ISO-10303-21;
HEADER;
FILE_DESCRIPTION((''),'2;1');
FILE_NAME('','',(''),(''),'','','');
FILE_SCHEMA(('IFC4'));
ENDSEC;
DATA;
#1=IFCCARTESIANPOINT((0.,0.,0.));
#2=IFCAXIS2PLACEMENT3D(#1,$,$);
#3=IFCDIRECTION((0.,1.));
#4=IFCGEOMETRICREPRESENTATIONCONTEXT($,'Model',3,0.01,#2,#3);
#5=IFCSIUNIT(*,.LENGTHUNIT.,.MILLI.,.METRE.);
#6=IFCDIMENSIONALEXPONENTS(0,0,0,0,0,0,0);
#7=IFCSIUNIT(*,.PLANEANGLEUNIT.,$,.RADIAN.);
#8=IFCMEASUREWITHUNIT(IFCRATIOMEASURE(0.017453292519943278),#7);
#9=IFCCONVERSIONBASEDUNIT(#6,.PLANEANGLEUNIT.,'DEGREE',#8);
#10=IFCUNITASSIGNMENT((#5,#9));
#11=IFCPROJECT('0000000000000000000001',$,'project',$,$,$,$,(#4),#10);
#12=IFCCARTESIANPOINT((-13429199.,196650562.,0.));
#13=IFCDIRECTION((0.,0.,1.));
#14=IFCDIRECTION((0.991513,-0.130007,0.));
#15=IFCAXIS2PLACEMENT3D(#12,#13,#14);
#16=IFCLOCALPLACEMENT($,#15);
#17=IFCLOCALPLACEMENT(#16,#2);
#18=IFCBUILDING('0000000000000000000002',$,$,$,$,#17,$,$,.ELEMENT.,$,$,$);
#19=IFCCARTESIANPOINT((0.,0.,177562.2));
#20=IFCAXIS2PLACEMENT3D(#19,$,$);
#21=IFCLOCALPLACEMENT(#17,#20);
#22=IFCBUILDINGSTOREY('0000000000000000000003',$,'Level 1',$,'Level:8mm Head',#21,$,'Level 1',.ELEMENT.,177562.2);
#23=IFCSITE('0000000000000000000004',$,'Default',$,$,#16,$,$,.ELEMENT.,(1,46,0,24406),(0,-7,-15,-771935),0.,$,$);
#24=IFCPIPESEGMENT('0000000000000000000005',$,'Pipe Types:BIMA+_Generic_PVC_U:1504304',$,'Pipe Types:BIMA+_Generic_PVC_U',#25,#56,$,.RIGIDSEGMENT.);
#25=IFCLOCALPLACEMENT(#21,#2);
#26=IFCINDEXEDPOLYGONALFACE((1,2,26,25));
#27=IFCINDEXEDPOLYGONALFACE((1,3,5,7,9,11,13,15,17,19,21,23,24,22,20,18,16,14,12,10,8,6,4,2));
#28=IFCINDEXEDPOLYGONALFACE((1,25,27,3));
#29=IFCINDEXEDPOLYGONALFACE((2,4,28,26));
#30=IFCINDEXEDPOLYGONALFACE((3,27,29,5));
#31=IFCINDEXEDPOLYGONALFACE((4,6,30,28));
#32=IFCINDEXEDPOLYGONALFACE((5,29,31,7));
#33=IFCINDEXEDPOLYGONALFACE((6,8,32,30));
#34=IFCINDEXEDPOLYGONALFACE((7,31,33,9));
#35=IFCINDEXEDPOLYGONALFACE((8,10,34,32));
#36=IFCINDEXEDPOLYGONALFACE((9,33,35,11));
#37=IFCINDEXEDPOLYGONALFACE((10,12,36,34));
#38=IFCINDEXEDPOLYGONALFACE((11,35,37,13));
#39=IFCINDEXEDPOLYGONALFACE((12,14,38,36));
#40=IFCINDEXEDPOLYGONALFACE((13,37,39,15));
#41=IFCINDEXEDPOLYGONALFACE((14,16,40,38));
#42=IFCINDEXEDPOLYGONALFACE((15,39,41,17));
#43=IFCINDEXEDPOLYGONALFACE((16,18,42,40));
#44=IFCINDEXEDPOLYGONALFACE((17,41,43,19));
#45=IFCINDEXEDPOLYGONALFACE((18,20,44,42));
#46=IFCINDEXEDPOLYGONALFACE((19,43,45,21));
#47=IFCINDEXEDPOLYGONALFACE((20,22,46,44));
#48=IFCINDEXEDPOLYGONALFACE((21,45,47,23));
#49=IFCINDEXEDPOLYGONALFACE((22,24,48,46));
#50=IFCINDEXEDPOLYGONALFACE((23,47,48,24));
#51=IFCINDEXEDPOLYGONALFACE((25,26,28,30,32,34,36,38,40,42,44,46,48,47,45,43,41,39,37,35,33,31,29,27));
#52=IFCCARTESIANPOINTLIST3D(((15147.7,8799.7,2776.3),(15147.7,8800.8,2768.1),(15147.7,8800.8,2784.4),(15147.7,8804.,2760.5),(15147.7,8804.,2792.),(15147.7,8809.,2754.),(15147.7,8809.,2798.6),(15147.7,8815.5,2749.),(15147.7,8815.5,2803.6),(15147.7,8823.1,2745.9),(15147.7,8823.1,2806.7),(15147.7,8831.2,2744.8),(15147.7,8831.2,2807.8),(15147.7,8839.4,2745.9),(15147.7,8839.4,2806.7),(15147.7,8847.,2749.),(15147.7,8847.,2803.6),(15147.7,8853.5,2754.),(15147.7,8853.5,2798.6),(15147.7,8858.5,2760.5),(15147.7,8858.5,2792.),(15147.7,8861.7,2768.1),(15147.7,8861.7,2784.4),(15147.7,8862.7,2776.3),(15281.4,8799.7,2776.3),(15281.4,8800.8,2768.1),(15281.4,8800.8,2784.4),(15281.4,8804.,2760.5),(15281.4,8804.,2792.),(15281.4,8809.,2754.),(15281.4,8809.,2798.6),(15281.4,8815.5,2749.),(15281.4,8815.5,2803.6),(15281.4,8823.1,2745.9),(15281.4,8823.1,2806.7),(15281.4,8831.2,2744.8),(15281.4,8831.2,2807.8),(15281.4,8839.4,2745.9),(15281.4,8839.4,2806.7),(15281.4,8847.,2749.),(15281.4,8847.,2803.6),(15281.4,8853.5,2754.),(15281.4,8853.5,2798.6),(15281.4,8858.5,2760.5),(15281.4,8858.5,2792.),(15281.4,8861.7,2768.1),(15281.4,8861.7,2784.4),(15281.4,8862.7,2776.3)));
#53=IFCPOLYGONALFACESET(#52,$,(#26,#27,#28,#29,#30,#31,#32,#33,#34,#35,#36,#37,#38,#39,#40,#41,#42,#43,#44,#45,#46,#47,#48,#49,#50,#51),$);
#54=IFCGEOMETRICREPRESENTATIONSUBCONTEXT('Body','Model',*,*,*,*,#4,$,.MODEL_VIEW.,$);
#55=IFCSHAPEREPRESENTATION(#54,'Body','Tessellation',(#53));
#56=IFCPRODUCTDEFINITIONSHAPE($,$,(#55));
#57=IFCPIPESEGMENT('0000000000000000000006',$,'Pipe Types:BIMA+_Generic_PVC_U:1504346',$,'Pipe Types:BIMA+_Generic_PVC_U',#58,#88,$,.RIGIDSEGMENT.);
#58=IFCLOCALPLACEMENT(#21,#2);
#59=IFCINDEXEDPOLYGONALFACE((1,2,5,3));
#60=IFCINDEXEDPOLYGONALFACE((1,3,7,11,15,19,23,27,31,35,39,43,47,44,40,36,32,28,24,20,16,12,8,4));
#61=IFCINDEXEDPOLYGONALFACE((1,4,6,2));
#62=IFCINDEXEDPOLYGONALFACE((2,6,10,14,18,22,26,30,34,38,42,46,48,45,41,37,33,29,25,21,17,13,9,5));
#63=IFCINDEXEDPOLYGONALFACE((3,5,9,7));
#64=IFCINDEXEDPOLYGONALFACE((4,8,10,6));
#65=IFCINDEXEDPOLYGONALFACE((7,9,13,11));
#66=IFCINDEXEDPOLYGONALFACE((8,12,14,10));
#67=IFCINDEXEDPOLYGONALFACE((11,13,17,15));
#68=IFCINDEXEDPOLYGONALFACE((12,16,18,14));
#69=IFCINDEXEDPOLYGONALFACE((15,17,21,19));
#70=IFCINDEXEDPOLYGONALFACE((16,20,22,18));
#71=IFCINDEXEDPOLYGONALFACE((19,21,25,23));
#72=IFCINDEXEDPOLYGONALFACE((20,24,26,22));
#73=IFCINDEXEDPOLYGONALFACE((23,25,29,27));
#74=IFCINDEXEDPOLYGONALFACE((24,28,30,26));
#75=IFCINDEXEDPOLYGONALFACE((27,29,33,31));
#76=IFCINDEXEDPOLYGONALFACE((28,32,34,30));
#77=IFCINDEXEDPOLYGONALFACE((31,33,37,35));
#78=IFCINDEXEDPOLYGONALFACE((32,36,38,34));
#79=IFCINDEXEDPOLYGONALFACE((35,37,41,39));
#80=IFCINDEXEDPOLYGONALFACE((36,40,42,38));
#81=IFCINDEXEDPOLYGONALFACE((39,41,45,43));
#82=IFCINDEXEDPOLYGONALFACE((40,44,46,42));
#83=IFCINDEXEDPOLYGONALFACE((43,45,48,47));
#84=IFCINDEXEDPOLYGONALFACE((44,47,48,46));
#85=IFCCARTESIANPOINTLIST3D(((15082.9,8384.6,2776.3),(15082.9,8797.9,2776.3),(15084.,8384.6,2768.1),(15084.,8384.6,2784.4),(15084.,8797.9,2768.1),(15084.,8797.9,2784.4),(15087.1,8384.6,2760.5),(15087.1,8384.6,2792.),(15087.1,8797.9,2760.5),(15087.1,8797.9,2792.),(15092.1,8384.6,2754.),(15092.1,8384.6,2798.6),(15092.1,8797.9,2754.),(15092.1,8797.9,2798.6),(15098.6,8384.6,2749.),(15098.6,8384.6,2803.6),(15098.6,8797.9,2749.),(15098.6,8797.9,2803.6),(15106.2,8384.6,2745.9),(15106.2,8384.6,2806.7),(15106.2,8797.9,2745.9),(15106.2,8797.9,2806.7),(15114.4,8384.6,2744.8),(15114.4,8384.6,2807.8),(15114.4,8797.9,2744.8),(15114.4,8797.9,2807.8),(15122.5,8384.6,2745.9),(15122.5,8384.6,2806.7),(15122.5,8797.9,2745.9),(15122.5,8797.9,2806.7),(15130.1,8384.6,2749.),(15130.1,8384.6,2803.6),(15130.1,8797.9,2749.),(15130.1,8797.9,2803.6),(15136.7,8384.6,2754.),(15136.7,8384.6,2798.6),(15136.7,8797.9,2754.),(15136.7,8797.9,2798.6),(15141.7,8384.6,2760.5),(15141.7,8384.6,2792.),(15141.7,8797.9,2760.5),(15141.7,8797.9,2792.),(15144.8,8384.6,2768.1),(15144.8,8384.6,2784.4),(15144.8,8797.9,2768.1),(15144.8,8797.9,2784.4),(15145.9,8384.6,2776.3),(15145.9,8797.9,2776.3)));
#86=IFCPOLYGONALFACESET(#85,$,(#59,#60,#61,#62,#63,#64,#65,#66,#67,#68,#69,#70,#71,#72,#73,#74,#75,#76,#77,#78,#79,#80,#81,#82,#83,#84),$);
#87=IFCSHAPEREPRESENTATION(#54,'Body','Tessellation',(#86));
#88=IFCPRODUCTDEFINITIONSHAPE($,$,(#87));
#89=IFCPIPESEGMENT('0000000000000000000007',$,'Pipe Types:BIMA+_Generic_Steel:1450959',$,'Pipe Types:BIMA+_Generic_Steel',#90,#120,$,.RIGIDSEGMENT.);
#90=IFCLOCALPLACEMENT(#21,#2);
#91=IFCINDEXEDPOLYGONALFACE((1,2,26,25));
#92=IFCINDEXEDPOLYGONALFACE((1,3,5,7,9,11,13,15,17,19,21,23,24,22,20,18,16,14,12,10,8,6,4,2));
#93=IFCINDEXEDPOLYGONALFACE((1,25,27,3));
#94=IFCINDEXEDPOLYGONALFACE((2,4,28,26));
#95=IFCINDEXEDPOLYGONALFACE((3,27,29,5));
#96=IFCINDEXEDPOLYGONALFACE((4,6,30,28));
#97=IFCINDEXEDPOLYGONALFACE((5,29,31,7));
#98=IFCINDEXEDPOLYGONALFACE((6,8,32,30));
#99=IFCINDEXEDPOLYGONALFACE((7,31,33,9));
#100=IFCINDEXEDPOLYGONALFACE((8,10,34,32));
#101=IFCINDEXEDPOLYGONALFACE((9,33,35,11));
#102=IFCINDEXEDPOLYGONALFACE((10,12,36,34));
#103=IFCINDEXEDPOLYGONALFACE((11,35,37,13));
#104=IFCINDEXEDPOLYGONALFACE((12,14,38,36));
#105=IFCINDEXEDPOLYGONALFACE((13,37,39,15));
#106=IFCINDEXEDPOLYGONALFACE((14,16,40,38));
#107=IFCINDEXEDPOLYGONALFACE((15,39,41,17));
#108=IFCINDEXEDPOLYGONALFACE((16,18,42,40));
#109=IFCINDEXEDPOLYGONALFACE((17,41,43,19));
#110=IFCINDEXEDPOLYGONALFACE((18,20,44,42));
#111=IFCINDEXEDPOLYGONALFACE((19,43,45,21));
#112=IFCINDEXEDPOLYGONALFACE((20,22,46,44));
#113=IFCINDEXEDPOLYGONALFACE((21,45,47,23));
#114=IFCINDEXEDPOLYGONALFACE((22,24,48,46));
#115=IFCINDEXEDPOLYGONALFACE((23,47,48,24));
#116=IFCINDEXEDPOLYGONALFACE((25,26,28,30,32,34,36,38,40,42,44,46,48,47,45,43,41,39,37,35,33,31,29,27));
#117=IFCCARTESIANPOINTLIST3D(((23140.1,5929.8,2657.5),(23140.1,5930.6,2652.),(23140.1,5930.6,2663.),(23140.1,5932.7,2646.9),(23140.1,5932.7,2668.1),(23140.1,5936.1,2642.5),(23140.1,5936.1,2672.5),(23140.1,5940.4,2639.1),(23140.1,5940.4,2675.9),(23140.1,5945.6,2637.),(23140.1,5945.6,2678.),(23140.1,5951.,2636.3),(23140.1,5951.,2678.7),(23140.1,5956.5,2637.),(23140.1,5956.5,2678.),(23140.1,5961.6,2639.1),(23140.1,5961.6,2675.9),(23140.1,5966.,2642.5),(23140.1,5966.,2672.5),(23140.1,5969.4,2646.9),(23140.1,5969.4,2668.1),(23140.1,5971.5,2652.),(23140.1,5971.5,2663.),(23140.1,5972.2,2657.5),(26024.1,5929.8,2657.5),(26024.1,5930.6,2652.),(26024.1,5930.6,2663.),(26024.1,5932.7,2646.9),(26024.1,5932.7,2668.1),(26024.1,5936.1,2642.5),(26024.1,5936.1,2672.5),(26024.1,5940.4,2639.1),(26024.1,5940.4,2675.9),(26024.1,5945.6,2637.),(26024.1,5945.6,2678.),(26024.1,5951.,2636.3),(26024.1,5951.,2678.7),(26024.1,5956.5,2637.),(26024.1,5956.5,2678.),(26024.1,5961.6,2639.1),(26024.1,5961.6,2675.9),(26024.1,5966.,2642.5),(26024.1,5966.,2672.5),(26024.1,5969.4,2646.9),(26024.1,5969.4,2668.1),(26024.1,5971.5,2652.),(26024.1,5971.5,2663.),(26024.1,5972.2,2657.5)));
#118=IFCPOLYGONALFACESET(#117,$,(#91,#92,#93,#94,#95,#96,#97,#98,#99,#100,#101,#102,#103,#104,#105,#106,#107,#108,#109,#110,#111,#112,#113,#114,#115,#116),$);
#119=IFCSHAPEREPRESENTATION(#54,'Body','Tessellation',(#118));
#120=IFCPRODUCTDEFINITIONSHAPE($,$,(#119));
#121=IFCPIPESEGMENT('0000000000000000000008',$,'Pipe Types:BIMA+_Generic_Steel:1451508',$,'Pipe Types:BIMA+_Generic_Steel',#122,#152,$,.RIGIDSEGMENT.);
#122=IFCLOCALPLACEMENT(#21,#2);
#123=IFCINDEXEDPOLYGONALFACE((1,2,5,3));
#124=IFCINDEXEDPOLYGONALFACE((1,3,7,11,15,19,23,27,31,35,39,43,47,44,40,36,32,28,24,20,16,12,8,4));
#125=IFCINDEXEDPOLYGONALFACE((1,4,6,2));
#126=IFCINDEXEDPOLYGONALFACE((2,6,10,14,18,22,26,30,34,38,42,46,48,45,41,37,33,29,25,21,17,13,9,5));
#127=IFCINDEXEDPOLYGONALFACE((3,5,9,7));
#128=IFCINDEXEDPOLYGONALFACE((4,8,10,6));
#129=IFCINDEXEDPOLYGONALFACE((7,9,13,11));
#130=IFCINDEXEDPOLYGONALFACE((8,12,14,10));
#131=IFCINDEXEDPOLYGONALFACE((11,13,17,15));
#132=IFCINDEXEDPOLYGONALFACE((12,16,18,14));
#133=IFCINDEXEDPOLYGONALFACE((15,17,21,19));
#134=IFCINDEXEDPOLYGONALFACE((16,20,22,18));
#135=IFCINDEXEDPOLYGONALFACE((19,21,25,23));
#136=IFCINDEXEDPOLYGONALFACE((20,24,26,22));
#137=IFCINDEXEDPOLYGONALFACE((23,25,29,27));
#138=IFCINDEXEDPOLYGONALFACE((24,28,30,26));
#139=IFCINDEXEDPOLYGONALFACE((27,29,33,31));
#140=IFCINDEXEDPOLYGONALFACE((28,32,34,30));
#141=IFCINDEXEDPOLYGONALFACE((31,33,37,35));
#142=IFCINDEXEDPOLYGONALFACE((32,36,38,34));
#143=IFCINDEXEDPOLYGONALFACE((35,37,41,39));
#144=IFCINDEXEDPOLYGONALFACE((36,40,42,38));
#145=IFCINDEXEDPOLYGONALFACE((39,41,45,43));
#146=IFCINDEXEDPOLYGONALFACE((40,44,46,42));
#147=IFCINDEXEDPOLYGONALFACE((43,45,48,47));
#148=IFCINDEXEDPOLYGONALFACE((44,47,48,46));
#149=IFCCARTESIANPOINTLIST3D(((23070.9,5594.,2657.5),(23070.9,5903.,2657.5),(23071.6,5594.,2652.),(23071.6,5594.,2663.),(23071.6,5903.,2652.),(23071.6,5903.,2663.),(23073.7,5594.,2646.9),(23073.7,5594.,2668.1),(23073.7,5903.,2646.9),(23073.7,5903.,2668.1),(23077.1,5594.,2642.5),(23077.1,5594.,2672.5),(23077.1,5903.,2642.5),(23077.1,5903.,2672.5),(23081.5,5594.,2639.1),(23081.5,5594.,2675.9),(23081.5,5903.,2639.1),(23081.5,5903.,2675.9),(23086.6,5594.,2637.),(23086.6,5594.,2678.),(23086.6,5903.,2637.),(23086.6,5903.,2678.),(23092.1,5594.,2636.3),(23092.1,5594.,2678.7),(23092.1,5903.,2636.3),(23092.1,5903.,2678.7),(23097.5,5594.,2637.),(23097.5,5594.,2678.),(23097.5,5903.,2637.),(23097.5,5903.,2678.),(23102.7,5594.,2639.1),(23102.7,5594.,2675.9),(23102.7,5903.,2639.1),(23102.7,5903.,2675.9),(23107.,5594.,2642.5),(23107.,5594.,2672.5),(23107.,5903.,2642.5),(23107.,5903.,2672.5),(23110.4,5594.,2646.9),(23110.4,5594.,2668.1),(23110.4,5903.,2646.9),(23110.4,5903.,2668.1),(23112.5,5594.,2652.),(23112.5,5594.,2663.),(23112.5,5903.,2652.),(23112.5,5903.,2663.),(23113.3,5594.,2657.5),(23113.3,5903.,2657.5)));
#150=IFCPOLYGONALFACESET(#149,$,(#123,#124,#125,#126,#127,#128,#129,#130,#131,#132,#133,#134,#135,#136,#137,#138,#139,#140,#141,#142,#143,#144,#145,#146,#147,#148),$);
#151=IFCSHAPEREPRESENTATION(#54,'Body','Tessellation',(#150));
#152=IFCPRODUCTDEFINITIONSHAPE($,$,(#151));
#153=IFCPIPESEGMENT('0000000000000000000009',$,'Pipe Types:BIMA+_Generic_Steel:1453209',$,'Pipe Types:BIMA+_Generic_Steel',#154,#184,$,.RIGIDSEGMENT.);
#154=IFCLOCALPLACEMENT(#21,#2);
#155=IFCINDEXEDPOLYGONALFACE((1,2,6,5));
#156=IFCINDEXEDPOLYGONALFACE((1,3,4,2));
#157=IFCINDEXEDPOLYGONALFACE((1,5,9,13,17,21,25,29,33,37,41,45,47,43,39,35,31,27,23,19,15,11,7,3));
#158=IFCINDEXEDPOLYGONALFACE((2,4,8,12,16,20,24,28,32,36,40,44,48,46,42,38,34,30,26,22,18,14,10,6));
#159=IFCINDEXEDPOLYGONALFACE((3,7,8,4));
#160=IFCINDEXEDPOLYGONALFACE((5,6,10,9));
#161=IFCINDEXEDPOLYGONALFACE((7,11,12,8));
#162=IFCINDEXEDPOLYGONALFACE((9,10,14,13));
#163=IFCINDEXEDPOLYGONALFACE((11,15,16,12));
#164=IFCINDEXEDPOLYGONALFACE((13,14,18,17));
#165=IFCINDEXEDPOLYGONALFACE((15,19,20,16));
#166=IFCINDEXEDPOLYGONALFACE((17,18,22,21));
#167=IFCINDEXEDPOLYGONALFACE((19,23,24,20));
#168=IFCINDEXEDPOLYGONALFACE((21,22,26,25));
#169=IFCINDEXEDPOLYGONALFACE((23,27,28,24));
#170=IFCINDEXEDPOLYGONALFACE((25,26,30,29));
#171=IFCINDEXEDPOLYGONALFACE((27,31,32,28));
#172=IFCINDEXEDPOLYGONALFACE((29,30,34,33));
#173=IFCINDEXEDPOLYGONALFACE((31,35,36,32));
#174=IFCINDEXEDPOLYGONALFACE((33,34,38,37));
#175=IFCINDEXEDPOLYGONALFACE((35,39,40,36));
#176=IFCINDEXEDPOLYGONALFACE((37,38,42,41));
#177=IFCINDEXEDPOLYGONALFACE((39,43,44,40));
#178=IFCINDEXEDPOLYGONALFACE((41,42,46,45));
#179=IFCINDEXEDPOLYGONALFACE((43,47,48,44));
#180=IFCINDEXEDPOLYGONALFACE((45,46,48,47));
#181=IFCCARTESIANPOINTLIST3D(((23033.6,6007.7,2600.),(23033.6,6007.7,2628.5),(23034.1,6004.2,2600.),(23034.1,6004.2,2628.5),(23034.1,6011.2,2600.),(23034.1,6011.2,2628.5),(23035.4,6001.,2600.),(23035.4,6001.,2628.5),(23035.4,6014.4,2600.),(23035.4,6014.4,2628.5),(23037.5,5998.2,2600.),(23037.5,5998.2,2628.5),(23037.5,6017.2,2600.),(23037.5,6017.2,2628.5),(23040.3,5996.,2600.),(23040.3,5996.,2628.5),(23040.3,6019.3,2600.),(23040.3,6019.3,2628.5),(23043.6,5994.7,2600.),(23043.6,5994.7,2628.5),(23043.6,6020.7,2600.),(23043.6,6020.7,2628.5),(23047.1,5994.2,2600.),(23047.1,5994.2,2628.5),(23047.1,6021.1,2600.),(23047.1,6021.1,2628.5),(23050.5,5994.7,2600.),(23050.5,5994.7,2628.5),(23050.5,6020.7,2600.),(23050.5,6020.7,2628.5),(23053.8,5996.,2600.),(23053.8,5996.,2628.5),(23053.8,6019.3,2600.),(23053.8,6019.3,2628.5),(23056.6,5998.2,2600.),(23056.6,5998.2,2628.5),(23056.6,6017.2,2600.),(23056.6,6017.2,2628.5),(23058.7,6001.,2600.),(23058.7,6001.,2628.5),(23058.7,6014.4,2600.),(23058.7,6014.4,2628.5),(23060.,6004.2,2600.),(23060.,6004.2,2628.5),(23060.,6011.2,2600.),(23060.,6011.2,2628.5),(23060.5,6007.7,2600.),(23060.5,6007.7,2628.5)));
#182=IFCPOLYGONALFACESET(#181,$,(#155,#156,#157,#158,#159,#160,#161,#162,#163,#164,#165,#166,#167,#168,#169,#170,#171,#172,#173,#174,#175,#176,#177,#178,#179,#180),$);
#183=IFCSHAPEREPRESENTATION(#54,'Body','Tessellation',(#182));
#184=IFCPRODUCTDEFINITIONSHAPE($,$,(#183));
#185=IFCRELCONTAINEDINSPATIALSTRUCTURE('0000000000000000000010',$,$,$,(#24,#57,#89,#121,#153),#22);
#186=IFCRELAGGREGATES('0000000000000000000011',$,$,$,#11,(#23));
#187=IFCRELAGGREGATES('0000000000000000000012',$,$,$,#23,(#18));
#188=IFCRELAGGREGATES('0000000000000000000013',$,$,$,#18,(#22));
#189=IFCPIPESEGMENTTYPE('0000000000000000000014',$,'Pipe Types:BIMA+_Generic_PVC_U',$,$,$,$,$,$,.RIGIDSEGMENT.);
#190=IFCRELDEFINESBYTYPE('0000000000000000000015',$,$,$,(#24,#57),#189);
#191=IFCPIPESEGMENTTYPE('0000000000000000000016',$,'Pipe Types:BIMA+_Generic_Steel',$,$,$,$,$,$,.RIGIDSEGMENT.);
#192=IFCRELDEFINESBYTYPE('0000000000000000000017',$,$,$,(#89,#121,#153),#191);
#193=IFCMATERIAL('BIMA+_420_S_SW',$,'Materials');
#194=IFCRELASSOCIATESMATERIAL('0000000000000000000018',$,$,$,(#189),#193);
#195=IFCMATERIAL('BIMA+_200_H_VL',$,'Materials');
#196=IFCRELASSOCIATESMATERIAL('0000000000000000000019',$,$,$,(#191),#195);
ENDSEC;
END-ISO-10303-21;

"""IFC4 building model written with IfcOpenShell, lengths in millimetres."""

from ifc_helpers import new_model, entity, si_unit, converted_unit, direction, frame, origin, place, context, subcontext, project, spatial, arc, indexed_curve, outline, extrude, material, type_object, element, save


model = new_model("IFC4")

# Units and contexts
model_context = context("Model", 3, precision=0.01, world=origin(), true_north=direction((0.0, 1.0)))
body_context = subcontext(model_context, "Body", "Model", "MODEL_VIEW")
ifc_project = project(units=[si_unit("LENGTHUNIT", "METRE", prefix="MILLI"), converted_unit("PLANEANGLEUNIT", "DEGREE", entity("IfcRatioMeasure", 0.017453292519943278), si_unit("PLANEANGLEUNIT", "RADIAN"), dimensions=[0, 0, 0, 0, 0, 0, 0])], contexts=[model_context])

# Site, building, storey
site_placement = place(None, frame((-13429199.0, 196650562.0, 0.0), z_axis=(0.0, 0.0, 1.0), x_axis=(0.991513, -0.130007, 0.0)))
site = spatial("IfcSite", under=ifc_project, at=site_placement, Name="Default", CompositionType="ELEMENT", RefLatitude=(1, 46, 0, 24406), RefLongitude=(0, -7, -15, -771935), RefElevation=0.0)
building_placement = place(site_placement, origin())
building = spatial("IfcBuilding", under=site, at=building_placement, CompositionType="ELEMENT")
storey_placement = place(building_placement, frame((0.0, 0.0, 177562.2)))
storey = spatial("IfcBuildingStorey", under=building, at=storey_placement, Name="Level 1", ObjectType="Level:8mm Head", LongName="Level 1", CompositionType="ELEMENT", Elevation=177562.2)

# Pipe segments
ifc_material_1 = material(Name="BIMA+_420_S_SW", Category="Materials")
pipe_segment_type_1 = type_object("IfcPipeSegmentType", Name="Pipe Types:BIMA+_Generic_PVC_U", PredefinedType="RIGIDSEGMENT", material=ifc_material_1)
pipe_segment_1_placement = place(storey_placement, frame((15147.7, 8798.2, 2743.2)))
element("IfcPipeSegment", 1, at=pipe_segment_1_placement, inside=storey, type_object=pipe_segment_type_1, Name="Pipe Types:BIMA+_Generic_PVC_U:1504304", ObjectType="Pipe Types:BIMA+_Generic_PVC_U", PredefinedType="RIGIDSEGMENT", context=body_context, shape_type="SweptSolid", body=[
    extrude(outline(indexed_curve([(31.5, 0.0), (22.3, 22.3), (0.0, 31.5), (-22.3, 22.3), (-31.5, 0.0), (-22.3, -22.3), (0.0, -31.5), (22.3, -22.3)], segments=[arc(1, 2, 3), arc(3, 4, 5), arc(5, 6, 7), arc(7, 8, 1)], self_intersect=False)), frame((0.0, 33.1, 33.1), z_axis=(1.0, 0.0, 0.0), x_axis=(0.0, 1.0, 0.0)), (0.0, 0.0, 1.0), 133.6),
])
pipe_segment_2_placement = place(storey_placement, frame((15081.3, 8384.6, 2743.2)))
element("IfcPipeSegment", 2, at=pipe_segment_2_placement, inside=storey, type_object=pipe_segment_type_1, Name="Pipe Types:BIMA+_Generic_PVC_U:1504346", ObjectType="Pipe Types:BIMA+_Generic_PVC_U", PredefinedType="RIGIDSEGMENT", context=body_context, shape_type="SweptSolid", body=[
    extrude(outline(indexed_curve([(31.5, 0.0), (22.3, 22.3), (0.0, 31.5), (-22.3, 22.3), (-31.5, 0.0), (-22.3, -22.3), (0.0, -31.5), (22.3, -22.3)], segments=[arc(1, 2, 3), arc(3, 4, 5), arc(5, 6, 7), arc(7, 8, 1)], self_intersect=False)), frame((33.1, 0.0, 33.1), z_axis=(0.0, 1.0, 0.0), x_axis=(1.0, 0.0, 0.0)), (0.0, 0.0, 1.0), 413.3),
])
ifc_material_2 = material(Name="BIMA+_200_H_VL", Category="Materials")
pipe_segment_type_2 = type_object("IfcPipeSegmentType", Name="Pipe Types:BIMA+_Generic_Steel", PredefinedType="RIGIDSEGMENT", material=ifc_material_2)
pipe_segment_3_placement = place(storey_placement, frame((23140.1, 5928.3, 2634.7)))
element("IfcPipeSegment", 3, at=pipe_segment_3_placement, inside=storey, type_object=pipe_segment_type_2, Name="Pipe Types:BIMA+_Generic_Steel:1450959", ObjectType="Pipe Types:BIMA+_Generic_Steel", PredefinedType="RIGIDSEGMENT", context=body_context, shape_type="SweptSolid", body=[
    extrude(outline(indexed_curve([(21.2, 0.0), (15.0, 15.0), (0.0, 21.2), (-15.0, 15.0), (-21.2, 0.0), (-15.0, -15.0), (0.0, -21.2), (15.0, -15.0)], segments=[arc(1, 2, 3), arc(3, 4, 5), arc(5, 6, 7), arc(7, 8, 1)], self_intersect=False)), frame((0.0, 22.8, 22.8), z_axis=(1.0, 0.0, 0.0), x_axis=(0.0, 1.0, 0.0)), (0.0, 0.0, 1.0), 2884.0),
])
pipe_segment_4_placement = place(storey_placement, frame((23069.3, 5594.0, 2634.7)))
element("IfcPipeSegment", 4, at=pipe_segment_4_placement, inside=storey, type_object=pipe_segment_type_2, Name="Pipe Types:BIMA+_Generic_Steel:1451508", ObjectType="Pipe Types:BIMA+_Generic_Steel", PredefinedType="RIGIDSEGMENT", context=body_context, shape_type="SweptSolid", body=[
    extrude(outline(indexed_curve([(21.2, 0.0), (15.0, 15.0), (0.0, 21.2), (-15.0, 15.0), (-21.2, 0.0), (-15.0, -15.0), (0.0, -21.2), (15.0, -15.0)], segments=[arc(1, 2, 3), arc(3, 4, 5), arc(5, 6, 7), arc(7, 8, 1)], self_intersect=False)), frame((22.8, 0.0, 22.8), z_axis=(0.0, 1.0, 0.0), x_axis=(-1.0, 0.0, 0.0)), (0.0, 0.0, 1.0), 309.0),
])
pipe_segment_5_placement = place(storey_placement, frame((23032.0, 5992.7, 2600.0)))
element("IfcPipeSegment", 5, at=pipe_segment_5_placement, inside=storey, type_object=pipe_segment_type_2, Name="Pipe Types:BIMA+_Generic_Steel:1453209", ObjectType="Pipe Types:BIMA+_Generic_Steel", PredefinedType="RIGIDSEGMENT", context=body_context, shape_type="SweptSolid", body=[
    extrude(outline(indexed_curve([(13.5, 0.0), (9.5, 9.5), (0.0, 13.5), (-9.5, 9.5), (-13.5, 0.0), (-9.5, -9.5), (0.0, -13.4), (9.5, -9.5)], segments=[arc(1, 2, 3), arc(3, 4, 5), arc(5, 6, 7), arc(7, 8, 1)], self_intersect=False)), frame((15.0, 15.0, 0.0), z_axis=(0.0, 0.0, 1.0), x_axis=(-1.0, 0.0, 0.0)), (0.0, 0.0, 1.0), 28.5),
])

save(model, "model.ifc")
